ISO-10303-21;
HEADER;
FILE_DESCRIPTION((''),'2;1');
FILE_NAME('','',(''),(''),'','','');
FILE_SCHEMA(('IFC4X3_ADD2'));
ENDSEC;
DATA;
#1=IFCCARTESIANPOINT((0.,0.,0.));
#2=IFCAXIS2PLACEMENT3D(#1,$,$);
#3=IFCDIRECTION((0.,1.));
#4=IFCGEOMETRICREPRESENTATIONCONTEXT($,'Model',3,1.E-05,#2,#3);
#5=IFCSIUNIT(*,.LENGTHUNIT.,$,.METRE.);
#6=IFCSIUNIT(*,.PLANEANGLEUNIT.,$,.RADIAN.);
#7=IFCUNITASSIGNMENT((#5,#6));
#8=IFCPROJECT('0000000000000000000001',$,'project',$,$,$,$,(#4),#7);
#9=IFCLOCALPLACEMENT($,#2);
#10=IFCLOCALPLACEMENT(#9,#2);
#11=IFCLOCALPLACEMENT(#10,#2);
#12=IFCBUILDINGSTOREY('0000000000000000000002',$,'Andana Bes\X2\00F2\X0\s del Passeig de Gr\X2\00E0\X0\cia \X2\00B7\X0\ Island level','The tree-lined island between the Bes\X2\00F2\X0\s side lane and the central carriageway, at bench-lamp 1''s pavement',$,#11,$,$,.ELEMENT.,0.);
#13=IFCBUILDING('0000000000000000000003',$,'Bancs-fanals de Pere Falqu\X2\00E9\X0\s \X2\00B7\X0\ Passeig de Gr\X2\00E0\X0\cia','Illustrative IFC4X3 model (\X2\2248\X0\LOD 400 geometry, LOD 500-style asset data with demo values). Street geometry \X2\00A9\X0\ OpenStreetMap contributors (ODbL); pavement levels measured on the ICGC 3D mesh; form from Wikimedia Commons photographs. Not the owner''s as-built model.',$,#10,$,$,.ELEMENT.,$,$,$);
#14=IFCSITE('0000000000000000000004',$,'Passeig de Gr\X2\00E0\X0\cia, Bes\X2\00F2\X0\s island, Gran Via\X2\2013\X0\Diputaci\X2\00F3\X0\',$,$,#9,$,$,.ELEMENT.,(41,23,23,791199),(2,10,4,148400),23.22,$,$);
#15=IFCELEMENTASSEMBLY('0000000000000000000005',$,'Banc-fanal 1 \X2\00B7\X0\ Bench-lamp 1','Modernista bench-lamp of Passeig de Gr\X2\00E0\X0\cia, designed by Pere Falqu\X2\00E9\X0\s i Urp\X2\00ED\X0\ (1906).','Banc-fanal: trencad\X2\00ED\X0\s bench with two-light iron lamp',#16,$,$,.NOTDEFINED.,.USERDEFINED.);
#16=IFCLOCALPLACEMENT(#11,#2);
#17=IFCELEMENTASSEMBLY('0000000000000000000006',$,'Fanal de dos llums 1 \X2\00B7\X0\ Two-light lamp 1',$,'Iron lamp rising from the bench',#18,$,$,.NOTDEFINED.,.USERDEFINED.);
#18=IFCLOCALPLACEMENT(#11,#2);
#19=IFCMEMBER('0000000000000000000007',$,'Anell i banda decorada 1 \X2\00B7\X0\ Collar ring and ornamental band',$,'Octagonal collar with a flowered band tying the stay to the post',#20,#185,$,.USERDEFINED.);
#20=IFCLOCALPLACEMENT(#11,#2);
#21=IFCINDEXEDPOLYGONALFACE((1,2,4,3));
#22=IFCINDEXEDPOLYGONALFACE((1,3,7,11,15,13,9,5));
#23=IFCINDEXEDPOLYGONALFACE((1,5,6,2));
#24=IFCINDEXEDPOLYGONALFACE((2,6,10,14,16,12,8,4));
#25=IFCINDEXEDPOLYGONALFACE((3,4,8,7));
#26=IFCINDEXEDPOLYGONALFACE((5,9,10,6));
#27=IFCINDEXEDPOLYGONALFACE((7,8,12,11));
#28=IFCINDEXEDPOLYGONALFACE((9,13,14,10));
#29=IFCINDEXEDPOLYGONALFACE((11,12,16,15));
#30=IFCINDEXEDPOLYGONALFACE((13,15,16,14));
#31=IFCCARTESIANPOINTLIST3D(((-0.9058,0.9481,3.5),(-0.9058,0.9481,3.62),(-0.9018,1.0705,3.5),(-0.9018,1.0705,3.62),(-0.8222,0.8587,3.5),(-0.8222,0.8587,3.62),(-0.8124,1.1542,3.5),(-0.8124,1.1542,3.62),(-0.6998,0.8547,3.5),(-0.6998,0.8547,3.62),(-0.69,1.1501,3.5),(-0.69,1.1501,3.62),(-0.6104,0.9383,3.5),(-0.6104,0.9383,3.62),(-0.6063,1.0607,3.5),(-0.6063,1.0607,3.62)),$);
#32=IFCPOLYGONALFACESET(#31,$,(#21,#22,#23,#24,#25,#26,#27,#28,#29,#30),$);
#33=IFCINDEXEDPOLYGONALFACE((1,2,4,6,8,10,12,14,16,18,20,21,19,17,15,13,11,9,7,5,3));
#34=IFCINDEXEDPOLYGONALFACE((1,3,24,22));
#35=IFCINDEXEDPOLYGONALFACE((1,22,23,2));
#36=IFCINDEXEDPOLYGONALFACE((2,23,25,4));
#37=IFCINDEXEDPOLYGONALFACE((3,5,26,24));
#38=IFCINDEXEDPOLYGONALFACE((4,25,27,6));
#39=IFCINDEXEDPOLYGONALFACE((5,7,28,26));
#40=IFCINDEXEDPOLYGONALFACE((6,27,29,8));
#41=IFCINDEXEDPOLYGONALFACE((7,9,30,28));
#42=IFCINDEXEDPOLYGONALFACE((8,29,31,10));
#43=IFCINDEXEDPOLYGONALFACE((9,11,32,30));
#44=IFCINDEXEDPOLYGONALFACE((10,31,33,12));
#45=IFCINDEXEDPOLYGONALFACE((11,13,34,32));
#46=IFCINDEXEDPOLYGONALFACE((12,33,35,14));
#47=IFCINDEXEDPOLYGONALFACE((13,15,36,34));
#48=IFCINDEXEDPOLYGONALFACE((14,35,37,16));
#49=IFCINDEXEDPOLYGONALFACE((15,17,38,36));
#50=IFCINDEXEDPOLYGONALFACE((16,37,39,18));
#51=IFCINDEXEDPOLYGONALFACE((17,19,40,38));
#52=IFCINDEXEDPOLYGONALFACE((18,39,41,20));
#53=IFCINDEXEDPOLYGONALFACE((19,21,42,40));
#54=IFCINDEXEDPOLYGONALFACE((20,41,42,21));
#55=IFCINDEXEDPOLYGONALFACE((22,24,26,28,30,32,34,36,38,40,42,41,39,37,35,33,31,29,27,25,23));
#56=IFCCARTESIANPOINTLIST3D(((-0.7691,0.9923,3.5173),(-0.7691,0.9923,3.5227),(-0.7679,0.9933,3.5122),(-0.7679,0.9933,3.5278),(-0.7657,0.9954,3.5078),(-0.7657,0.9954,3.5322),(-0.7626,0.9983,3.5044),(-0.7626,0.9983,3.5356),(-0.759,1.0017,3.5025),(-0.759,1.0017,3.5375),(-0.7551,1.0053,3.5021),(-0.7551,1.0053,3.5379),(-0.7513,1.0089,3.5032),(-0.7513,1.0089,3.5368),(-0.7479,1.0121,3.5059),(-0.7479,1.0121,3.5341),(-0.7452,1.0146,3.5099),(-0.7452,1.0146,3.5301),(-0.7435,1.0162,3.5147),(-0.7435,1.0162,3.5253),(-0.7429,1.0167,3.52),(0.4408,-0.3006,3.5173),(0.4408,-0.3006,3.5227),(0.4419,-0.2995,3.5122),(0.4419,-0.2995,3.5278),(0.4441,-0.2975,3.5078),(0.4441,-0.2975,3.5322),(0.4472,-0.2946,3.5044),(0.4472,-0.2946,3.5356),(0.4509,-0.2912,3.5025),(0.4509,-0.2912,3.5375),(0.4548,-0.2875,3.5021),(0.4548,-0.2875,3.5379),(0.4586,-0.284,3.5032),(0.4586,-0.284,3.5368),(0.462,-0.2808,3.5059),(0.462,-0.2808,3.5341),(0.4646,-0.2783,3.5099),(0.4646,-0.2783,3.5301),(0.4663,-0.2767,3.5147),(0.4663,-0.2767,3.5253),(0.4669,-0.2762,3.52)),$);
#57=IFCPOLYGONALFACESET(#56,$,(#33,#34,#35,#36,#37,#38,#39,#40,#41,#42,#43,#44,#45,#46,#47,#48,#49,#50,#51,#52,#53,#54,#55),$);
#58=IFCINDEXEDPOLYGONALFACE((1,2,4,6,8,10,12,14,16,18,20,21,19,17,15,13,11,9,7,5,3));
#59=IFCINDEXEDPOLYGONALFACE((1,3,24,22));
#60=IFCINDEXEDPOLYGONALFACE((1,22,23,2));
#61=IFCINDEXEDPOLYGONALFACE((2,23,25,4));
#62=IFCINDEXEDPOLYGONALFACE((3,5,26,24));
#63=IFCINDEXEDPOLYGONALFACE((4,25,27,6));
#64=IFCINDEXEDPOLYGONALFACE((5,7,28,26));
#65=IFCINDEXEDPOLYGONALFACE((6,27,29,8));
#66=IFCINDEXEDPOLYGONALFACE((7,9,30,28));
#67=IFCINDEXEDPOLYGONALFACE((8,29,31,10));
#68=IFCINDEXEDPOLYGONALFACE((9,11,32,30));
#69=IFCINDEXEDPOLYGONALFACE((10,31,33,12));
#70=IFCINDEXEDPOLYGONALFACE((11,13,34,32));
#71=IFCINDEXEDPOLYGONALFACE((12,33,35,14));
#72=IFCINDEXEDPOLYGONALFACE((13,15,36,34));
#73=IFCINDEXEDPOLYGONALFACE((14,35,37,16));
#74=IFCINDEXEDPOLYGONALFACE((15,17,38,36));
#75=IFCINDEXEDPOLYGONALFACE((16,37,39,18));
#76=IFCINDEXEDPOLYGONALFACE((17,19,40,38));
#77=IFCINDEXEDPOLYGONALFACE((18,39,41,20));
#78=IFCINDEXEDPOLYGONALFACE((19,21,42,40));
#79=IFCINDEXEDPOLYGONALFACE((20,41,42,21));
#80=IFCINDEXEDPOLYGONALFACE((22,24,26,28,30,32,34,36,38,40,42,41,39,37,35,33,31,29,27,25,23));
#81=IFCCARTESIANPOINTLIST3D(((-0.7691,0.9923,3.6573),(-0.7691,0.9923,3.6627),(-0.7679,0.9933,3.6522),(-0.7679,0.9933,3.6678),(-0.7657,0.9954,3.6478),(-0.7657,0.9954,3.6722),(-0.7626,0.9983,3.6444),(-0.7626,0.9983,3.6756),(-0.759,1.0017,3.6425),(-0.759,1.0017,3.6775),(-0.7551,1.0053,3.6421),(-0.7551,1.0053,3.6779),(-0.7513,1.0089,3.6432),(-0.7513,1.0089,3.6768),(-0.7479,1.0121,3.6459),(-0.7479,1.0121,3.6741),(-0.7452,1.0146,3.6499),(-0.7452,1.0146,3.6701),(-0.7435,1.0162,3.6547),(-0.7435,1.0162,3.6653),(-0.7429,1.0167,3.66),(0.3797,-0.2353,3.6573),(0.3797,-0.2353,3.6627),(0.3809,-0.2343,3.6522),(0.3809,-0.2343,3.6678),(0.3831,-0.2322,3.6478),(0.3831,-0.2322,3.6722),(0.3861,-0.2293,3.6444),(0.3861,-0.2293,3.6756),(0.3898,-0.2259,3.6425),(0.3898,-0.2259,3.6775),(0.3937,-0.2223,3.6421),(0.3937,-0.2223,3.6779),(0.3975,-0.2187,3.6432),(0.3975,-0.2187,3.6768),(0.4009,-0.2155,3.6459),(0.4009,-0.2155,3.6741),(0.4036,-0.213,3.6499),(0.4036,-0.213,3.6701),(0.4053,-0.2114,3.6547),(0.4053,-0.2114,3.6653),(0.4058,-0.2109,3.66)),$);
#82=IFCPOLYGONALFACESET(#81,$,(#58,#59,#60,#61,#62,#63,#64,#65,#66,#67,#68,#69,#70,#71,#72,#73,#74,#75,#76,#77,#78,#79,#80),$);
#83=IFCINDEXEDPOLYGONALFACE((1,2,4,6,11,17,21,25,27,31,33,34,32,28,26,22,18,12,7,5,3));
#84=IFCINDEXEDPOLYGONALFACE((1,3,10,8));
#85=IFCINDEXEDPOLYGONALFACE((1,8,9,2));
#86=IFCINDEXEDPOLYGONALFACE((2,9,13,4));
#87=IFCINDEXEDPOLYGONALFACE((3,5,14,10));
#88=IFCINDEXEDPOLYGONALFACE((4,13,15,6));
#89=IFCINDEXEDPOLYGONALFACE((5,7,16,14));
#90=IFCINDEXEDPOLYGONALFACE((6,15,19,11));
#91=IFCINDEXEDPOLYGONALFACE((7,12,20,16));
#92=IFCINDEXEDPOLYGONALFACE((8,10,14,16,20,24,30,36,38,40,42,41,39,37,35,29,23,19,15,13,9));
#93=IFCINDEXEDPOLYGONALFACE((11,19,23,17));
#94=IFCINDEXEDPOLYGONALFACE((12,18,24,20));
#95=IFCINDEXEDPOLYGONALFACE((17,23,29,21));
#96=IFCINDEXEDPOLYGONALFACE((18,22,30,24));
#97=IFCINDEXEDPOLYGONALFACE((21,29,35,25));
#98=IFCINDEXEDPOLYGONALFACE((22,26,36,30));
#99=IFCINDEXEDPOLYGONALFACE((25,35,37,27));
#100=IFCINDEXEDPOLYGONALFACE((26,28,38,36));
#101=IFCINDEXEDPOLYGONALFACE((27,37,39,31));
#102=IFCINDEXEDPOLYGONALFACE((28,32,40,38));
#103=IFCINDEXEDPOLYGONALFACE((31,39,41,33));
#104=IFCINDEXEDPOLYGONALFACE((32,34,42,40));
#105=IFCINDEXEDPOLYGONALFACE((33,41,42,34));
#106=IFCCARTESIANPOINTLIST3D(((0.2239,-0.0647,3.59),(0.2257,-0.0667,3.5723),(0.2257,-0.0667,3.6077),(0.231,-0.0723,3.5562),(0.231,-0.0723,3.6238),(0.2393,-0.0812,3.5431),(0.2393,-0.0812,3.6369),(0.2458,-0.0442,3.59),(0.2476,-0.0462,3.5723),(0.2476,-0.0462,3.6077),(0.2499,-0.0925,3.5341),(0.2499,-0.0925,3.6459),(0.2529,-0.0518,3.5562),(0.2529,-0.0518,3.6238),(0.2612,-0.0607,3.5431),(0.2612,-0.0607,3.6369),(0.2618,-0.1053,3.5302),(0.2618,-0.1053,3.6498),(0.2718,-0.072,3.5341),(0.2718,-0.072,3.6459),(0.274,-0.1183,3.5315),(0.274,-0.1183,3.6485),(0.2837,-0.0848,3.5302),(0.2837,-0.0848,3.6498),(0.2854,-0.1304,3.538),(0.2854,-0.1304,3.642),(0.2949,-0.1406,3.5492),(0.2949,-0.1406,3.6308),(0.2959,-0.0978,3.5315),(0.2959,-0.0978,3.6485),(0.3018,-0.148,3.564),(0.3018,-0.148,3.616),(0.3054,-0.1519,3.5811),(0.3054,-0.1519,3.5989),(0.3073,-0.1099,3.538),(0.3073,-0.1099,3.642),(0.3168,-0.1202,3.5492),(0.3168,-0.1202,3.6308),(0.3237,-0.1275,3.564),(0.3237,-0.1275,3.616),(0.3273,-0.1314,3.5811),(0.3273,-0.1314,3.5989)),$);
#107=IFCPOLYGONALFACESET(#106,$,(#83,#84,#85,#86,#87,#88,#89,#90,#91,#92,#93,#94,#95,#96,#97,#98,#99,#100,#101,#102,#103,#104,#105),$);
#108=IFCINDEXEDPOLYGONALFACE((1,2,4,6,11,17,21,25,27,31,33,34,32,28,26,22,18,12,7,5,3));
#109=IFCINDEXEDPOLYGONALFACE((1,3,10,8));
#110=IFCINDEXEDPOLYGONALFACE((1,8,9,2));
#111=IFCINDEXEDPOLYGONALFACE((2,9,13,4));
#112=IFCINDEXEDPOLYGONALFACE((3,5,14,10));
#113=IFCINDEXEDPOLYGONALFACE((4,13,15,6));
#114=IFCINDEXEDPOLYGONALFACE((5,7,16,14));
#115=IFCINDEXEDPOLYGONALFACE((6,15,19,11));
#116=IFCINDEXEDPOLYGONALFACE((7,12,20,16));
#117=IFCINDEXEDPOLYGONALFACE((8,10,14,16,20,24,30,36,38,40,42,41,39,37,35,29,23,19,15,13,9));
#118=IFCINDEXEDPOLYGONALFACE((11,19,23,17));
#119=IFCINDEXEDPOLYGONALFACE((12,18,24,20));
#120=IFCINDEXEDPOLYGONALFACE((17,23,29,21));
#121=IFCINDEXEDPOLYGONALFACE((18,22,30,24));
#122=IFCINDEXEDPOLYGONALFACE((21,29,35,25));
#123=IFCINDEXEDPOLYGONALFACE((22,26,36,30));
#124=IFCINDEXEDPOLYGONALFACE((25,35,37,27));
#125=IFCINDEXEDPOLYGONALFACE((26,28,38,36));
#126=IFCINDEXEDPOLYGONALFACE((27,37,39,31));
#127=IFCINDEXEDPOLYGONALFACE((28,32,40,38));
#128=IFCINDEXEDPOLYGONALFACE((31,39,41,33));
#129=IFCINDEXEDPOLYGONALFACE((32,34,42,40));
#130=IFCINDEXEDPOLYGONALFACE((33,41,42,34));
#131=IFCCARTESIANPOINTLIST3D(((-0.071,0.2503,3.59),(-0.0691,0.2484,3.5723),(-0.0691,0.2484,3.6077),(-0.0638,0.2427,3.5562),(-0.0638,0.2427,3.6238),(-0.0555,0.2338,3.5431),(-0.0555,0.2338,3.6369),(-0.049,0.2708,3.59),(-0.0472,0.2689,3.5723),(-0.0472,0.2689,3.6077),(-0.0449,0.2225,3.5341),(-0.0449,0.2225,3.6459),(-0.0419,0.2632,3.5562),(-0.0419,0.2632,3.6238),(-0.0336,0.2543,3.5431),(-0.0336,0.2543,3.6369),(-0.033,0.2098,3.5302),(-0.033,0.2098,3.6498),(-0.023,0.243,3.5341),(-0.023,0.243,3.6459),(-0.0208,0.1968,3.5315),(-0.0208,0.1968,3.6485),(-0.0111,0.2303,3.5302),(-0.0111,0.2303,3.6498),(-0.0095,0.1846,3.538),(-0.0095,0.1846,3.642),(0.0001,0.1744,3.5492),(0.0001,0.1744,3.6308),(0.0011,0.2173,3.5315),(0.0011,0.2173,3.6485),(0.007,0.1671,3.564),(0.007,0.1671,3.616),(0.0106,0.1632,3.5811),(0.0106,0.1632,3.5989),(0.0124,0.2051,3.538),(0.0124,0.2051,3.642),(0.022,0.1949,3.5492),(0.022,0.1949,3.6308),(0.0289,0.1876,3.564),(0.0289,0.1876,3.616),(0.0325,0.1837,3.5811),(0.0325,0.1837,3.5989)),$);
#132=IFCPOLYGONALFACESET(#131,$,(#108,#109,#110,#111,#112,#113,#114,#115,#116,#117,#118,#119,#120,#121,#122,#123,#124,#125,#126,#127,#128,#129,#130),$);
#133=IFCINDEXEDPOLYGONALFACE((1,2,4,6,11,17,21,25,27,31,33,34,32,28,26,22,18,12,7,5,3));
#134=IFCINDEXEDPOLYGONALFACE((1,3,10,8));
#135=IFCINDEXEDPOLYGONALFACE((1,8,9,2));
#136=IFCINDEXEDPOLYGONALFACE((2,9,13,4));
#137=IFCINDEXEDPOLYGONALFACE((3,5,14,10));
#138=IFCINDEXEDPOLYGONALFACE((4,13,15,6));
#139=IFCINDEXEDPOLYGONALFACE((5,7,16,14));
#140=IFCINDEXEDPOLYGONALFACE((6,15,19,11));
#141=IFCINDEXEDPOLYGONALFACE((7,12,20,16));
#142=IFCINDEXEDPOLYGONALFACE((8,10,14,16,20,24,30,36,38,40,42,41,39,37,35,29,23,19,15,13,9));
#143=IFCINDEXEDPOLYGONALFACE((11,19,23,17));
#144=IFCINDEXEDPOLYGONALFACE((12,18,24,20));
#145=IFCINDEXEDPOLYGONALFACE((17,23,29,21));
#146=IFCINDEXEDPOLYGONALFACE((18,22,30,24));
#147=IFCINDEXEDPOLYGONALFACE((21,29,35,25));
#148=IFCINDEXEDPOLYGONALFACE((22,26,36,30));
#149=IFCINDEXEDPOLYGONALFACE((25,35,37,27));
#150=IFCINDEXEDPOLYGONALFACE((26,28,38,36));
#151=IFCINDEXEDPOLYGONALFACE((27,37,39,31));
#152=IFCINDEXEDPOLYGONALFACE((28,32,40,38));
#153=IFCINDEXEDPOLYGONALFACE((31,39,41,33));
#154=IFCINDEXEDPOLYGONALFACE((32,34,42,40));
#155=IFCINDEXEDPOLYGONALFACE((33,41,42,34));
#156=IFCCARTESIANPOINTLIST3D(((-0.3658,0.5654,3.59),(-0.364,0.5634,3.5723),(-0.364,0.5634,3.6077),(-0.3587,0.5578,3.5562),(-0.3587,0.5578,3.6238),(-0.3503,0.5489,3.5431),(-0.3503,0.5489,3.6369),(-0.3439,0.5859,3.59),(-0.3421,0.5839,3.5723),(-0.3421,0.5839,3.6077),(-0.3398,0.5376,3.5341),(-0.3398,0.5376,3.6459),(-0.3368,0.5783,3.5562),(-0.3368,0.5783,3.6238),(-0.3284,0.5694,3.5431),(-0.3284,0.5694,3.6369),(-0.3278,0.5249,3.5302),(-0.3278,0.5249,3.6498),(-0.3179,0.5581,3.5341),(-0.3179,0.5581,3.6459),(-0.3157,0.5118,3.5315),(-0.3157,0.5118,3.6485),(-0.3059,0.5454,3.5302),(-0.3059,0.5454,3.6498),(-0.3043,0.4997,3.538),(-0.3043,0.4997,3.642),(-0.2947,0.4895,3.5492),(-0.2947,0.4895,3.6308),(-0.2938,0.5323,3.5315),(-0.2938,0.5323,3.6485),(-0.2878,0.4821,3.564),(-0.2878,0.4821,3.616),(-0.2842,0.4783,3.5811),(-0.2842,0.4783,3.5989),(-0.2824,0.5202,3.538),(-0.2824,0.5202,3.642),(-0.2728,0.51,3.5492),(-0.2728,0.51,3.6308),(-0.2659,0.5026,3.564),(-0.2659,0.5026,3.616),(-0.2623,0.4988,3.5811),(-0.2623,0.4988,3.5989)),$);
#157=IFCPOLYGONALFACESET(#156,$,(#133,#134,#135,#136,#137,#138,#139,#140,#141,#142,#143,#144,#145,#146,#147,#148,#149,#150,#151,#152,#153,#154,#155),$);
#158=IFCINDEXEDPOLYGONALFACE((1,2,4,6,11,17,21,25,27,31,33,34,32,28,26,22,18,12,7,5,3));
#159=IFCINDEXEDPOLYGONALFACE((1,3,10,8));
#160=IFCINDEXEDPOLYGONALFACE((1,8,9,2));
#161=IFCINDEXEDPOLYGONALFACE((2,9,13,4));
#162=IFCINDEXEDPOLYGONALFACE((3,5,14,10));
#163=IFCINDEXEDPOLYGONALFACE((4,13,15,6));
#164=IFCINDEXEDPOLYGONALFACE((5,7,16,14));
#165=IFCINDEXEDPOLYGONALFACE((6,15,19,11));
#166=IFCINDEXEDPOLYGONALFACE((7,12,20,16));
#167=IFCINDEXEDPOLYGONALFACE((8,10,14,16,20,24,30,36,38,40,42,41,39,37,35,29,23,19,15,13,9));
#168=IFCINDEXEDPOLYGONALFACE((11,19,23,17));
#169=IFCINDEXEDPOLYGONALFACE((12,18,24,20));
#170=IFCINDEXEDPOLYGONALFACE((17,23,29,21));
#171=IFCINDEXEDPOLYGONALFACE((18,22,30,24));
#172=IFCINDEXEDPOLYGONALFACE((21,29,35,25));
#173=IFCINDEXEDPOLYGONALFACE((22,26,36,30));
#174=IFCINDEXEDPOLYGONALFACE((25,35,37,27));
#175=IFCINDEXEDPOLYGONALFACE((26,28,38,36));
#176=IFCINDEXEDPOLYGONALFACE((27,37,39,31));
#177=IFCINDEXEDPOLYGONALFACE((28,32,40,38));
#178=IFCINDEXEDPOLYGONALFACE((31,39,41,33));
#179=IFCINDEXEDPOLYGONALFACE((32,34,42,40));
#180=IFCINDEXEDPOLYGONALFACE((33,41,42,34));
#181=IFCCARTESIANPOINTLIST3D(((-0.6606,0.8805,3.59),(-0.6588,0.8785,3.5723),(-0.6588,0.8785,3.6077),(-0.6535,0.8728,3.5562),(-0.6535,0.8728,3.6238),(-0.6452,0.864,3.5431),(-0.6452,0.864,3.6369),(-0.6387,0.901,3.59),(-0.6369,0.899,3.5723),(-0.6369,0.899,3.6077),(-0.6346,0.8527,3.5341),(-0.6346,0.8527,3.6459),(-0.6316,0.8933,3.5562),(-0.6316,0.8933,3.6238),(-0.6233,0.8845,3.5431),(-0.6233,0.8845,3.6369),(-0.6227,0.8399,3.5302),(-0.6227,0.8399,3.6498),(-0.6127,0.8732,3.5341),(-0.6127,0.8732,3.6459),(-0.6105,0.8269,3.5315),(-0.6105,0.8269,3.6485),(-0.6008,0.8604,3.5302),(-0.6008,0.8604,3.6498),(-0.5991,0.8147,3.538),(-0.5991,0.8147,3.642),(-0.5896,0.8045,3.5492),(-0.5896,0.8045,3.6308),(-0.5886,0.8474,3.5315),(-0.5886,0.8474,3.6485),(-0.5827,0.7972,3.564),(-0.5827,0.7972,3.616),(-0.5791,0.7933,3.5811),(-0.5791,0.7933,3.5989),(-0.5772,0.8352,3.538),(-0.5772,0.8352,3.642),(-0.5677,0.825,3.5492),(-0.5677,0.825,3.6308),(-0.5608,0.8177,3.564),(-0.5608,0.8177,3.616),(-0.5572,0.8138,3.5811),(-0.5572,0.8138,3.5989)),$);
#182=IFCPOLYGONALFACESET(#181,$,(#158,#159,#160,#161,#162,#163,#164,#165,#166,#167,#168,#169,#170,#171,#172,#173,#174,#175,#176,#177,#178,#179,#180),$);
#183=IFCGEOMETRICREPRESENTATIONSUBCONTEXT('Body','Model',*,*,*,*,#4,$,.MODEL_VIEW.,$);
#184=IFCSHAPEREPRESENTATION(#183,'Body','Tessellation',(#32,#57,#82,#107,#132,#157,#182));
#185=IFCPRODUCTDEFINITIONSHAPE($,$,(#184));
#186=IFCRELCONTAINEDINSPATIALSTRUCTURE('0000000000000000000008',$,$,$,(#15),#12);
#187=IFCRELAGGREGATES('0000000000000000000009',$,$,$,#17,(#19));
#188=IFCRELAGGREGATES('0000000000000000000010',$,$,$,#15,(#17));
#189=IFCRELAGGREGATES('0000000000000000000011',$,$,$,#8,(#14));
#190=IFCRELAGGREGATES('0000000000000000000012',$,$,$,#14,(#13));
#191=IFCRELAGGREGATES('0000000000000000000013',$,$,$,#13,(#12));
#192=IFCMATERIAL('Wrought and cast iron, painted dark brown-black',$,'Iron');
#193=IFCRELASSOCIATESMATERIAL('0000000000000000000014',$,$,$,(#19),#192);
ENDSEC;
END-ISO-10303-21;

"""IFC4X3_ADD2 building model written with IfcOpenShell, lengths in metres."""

from ifc_helpers import new_model, si_unit, direction, frame, origin, origin_2d_with_axis, place, context, subcontext, project, spatial, polyline, circle, outline, extrude, material, element, aggregate, save


model = new_model("IFC4X3_ADD2")

# Units and contexts
model_context = context("Model", 3, precision=1e-05, world=origin(), true_north=direction((0.0, 1.0)))
body_context = subcontext(model_context, "Body", "Model", "MODEL_VIEW")
ifc_project = project(units=[si_unit("LENGTHUNIT", "METRE"), si_unit("PLANEANGLEUNIT", "RADIAN")], contexts=[model_context])

# Site, building, storey
site_placement = place(None, origin())
site = spatial("IfcSite", under=ifc_project, at=site_placement, Name="Passeig de Gràcia, Besòs island, Gran Via–Diputació", CompositionType="ELEMENT", RefLatitude=(41, 23, 23, 791199), RefLongitude=(2, 10, 4, 148400), RefElevation=23.22)
building_placement = place(site_placement, origin())
building = spatial("IfcBuilding", under=site, at=building_placement, Name="Bancs-fanals de Pere Falqués · Passeig de Gràcia", Description="Illustrative IFC4X3 model (≈LOD 400 geometry, LOD 500-style asset data with demo values). Street geometry © OpenStreetMap contributors (ODbL); pavement levels measured on the ICGC 3D mesh; form from Wikimedia Commons photographs. Not the owner's as-built model.", CompositionType="ELEMENT")
storey_placement = place(building_placement, origin())
storey = spatial("IfcBuildingStorey", under=building, at=storey_placement, Name="Andana Besòs del Passeig de Gràcia · Island level", Description="The tree-lined island between the Besòs side lane and the central carriageway, at bench-lamp 1's pavement", CompositionType="ELEMENT", Elevation=0.0)

# Element assembly
assembly_1_placement = place(building_placement, origin())
assembly_1 = element("IfcElementAssembly", 1, at=assembly_1_placement, inside=storey, Name="Banc-fanal 1 · Bench-lamp 1", Description="Modernista bench-lamp of Passeig de Gràcia, designed by Pere Falqués i Urpí (1906).", ObjectType="Banc-fanal: trencadís bench with two-light iron lamp", AssemblyPlace="NOTDEFINED", PredefinedType="USERDEFINED")

# Element assembly
assembly_2_placement = place(building_placement, origin())
assembly_2 = element("IfcElementAssembly", 2, at=assembly_2_placement, Name="Fanal de dos llums 1 · Two-light lamp 1", ObjectType="Iron lamp rising from the bench", AssemblyPlace="NOTDEFINED", PredefinedType="USERDEFINED")
ifc_material_1 = material(Name="Wrought and cast iron, painted dark brown-black", Category="Iron")

# Member
member_1_placement = place(building_placement, origin())
member_1 = element("IfcMember", 3, at=member_1_placement, material=ifc_material_1, Name="Anell i banda decorada 1 · Collar ring and ornamental band", ObjectType="Octagonal collar with a flowered band tying the stay to the post", PredefinedType="USERDEFINED", context=body_context, shape_type="SweptSolid", body=[
    extrude(outline(polyline([(-0.9018, 1.0705), (-0.9058, 0.9481), (-0.8222, 0.8587), (-0.6998, 0.8547), (-0.6104, 0.9383), (-0.6063, 1.0607), (-0.69, 1.1501), (-0.8124, 1.1542), (-0.9018, 1.0705)])), frame((0.0, 0.0, 3.5)), (0.0, 0.0, 1.0), 0.12),
    extrude(circle(Radius=0.018, at=origin_2d_with_axis()), frame((0.4538, -0.2885, 3.52), z_axis=(-0.683274, 0.730162, 0.0), x_axis=(0.730162, 0.683274, 0.0)), (0.0, 0.0, 1.0), 1.7707),
    extrude(circle(Radius=0.018, at=origin_2d_with_axis()), frame((0.3927, -0.2232, 3.66), z_axis=(-0.683274, 0.730162, 0.0), x_axis=(0.730162, 0.683274, 0.0)), (0.0, 0.0, 1.0), 1.6813),
    extrude(circle(Radius=0.06, at=origin_2d_with_axis()), frame((0.2868, -0.088, 3.59), z_axis=(-0.730162, -0.683274, 0.0), x_axis=(-0.683274, 0.730162, 0.0)), (0.0, 0.0, 1.0), 0.03),
    extrude(circle(Radius=0.06, at=origin_2d_with_axis()), frame((-0.0081, 0.227, 3.59), z_axis=(-0.730162, -0.683274, 0.0), x_axis=(-0.683274, 0.730162, 0.0)), (0.0, 0.0, 1.0), 0.03),
    extrude(circle(Radius=0.06, at=origin_2d_with_axis()), frame((-0.3029, 0.5421, 3.59), z_axis=(-0.730162, -0.683274, 0.0), x_axis=(-0.683274, 0.730162, 0.0)), (0.0, 0.0, 1.0), 0.03),
    extrude(circle(Radius=0.06, at=origin_2d_with_axis()), frame((-0.5977, 0.8571, 3.59), z_axis=(-0.730162, -0.683274, 0.0), x_axis=(-0.683274, 0.730162, 0.0)), (0.0, 0.0, 1.0), 0.03),
])

aggregate(assembly_2, [member_1])

aggregate(assembly_1, [assembly_2])

save(model, "model.ifc")
